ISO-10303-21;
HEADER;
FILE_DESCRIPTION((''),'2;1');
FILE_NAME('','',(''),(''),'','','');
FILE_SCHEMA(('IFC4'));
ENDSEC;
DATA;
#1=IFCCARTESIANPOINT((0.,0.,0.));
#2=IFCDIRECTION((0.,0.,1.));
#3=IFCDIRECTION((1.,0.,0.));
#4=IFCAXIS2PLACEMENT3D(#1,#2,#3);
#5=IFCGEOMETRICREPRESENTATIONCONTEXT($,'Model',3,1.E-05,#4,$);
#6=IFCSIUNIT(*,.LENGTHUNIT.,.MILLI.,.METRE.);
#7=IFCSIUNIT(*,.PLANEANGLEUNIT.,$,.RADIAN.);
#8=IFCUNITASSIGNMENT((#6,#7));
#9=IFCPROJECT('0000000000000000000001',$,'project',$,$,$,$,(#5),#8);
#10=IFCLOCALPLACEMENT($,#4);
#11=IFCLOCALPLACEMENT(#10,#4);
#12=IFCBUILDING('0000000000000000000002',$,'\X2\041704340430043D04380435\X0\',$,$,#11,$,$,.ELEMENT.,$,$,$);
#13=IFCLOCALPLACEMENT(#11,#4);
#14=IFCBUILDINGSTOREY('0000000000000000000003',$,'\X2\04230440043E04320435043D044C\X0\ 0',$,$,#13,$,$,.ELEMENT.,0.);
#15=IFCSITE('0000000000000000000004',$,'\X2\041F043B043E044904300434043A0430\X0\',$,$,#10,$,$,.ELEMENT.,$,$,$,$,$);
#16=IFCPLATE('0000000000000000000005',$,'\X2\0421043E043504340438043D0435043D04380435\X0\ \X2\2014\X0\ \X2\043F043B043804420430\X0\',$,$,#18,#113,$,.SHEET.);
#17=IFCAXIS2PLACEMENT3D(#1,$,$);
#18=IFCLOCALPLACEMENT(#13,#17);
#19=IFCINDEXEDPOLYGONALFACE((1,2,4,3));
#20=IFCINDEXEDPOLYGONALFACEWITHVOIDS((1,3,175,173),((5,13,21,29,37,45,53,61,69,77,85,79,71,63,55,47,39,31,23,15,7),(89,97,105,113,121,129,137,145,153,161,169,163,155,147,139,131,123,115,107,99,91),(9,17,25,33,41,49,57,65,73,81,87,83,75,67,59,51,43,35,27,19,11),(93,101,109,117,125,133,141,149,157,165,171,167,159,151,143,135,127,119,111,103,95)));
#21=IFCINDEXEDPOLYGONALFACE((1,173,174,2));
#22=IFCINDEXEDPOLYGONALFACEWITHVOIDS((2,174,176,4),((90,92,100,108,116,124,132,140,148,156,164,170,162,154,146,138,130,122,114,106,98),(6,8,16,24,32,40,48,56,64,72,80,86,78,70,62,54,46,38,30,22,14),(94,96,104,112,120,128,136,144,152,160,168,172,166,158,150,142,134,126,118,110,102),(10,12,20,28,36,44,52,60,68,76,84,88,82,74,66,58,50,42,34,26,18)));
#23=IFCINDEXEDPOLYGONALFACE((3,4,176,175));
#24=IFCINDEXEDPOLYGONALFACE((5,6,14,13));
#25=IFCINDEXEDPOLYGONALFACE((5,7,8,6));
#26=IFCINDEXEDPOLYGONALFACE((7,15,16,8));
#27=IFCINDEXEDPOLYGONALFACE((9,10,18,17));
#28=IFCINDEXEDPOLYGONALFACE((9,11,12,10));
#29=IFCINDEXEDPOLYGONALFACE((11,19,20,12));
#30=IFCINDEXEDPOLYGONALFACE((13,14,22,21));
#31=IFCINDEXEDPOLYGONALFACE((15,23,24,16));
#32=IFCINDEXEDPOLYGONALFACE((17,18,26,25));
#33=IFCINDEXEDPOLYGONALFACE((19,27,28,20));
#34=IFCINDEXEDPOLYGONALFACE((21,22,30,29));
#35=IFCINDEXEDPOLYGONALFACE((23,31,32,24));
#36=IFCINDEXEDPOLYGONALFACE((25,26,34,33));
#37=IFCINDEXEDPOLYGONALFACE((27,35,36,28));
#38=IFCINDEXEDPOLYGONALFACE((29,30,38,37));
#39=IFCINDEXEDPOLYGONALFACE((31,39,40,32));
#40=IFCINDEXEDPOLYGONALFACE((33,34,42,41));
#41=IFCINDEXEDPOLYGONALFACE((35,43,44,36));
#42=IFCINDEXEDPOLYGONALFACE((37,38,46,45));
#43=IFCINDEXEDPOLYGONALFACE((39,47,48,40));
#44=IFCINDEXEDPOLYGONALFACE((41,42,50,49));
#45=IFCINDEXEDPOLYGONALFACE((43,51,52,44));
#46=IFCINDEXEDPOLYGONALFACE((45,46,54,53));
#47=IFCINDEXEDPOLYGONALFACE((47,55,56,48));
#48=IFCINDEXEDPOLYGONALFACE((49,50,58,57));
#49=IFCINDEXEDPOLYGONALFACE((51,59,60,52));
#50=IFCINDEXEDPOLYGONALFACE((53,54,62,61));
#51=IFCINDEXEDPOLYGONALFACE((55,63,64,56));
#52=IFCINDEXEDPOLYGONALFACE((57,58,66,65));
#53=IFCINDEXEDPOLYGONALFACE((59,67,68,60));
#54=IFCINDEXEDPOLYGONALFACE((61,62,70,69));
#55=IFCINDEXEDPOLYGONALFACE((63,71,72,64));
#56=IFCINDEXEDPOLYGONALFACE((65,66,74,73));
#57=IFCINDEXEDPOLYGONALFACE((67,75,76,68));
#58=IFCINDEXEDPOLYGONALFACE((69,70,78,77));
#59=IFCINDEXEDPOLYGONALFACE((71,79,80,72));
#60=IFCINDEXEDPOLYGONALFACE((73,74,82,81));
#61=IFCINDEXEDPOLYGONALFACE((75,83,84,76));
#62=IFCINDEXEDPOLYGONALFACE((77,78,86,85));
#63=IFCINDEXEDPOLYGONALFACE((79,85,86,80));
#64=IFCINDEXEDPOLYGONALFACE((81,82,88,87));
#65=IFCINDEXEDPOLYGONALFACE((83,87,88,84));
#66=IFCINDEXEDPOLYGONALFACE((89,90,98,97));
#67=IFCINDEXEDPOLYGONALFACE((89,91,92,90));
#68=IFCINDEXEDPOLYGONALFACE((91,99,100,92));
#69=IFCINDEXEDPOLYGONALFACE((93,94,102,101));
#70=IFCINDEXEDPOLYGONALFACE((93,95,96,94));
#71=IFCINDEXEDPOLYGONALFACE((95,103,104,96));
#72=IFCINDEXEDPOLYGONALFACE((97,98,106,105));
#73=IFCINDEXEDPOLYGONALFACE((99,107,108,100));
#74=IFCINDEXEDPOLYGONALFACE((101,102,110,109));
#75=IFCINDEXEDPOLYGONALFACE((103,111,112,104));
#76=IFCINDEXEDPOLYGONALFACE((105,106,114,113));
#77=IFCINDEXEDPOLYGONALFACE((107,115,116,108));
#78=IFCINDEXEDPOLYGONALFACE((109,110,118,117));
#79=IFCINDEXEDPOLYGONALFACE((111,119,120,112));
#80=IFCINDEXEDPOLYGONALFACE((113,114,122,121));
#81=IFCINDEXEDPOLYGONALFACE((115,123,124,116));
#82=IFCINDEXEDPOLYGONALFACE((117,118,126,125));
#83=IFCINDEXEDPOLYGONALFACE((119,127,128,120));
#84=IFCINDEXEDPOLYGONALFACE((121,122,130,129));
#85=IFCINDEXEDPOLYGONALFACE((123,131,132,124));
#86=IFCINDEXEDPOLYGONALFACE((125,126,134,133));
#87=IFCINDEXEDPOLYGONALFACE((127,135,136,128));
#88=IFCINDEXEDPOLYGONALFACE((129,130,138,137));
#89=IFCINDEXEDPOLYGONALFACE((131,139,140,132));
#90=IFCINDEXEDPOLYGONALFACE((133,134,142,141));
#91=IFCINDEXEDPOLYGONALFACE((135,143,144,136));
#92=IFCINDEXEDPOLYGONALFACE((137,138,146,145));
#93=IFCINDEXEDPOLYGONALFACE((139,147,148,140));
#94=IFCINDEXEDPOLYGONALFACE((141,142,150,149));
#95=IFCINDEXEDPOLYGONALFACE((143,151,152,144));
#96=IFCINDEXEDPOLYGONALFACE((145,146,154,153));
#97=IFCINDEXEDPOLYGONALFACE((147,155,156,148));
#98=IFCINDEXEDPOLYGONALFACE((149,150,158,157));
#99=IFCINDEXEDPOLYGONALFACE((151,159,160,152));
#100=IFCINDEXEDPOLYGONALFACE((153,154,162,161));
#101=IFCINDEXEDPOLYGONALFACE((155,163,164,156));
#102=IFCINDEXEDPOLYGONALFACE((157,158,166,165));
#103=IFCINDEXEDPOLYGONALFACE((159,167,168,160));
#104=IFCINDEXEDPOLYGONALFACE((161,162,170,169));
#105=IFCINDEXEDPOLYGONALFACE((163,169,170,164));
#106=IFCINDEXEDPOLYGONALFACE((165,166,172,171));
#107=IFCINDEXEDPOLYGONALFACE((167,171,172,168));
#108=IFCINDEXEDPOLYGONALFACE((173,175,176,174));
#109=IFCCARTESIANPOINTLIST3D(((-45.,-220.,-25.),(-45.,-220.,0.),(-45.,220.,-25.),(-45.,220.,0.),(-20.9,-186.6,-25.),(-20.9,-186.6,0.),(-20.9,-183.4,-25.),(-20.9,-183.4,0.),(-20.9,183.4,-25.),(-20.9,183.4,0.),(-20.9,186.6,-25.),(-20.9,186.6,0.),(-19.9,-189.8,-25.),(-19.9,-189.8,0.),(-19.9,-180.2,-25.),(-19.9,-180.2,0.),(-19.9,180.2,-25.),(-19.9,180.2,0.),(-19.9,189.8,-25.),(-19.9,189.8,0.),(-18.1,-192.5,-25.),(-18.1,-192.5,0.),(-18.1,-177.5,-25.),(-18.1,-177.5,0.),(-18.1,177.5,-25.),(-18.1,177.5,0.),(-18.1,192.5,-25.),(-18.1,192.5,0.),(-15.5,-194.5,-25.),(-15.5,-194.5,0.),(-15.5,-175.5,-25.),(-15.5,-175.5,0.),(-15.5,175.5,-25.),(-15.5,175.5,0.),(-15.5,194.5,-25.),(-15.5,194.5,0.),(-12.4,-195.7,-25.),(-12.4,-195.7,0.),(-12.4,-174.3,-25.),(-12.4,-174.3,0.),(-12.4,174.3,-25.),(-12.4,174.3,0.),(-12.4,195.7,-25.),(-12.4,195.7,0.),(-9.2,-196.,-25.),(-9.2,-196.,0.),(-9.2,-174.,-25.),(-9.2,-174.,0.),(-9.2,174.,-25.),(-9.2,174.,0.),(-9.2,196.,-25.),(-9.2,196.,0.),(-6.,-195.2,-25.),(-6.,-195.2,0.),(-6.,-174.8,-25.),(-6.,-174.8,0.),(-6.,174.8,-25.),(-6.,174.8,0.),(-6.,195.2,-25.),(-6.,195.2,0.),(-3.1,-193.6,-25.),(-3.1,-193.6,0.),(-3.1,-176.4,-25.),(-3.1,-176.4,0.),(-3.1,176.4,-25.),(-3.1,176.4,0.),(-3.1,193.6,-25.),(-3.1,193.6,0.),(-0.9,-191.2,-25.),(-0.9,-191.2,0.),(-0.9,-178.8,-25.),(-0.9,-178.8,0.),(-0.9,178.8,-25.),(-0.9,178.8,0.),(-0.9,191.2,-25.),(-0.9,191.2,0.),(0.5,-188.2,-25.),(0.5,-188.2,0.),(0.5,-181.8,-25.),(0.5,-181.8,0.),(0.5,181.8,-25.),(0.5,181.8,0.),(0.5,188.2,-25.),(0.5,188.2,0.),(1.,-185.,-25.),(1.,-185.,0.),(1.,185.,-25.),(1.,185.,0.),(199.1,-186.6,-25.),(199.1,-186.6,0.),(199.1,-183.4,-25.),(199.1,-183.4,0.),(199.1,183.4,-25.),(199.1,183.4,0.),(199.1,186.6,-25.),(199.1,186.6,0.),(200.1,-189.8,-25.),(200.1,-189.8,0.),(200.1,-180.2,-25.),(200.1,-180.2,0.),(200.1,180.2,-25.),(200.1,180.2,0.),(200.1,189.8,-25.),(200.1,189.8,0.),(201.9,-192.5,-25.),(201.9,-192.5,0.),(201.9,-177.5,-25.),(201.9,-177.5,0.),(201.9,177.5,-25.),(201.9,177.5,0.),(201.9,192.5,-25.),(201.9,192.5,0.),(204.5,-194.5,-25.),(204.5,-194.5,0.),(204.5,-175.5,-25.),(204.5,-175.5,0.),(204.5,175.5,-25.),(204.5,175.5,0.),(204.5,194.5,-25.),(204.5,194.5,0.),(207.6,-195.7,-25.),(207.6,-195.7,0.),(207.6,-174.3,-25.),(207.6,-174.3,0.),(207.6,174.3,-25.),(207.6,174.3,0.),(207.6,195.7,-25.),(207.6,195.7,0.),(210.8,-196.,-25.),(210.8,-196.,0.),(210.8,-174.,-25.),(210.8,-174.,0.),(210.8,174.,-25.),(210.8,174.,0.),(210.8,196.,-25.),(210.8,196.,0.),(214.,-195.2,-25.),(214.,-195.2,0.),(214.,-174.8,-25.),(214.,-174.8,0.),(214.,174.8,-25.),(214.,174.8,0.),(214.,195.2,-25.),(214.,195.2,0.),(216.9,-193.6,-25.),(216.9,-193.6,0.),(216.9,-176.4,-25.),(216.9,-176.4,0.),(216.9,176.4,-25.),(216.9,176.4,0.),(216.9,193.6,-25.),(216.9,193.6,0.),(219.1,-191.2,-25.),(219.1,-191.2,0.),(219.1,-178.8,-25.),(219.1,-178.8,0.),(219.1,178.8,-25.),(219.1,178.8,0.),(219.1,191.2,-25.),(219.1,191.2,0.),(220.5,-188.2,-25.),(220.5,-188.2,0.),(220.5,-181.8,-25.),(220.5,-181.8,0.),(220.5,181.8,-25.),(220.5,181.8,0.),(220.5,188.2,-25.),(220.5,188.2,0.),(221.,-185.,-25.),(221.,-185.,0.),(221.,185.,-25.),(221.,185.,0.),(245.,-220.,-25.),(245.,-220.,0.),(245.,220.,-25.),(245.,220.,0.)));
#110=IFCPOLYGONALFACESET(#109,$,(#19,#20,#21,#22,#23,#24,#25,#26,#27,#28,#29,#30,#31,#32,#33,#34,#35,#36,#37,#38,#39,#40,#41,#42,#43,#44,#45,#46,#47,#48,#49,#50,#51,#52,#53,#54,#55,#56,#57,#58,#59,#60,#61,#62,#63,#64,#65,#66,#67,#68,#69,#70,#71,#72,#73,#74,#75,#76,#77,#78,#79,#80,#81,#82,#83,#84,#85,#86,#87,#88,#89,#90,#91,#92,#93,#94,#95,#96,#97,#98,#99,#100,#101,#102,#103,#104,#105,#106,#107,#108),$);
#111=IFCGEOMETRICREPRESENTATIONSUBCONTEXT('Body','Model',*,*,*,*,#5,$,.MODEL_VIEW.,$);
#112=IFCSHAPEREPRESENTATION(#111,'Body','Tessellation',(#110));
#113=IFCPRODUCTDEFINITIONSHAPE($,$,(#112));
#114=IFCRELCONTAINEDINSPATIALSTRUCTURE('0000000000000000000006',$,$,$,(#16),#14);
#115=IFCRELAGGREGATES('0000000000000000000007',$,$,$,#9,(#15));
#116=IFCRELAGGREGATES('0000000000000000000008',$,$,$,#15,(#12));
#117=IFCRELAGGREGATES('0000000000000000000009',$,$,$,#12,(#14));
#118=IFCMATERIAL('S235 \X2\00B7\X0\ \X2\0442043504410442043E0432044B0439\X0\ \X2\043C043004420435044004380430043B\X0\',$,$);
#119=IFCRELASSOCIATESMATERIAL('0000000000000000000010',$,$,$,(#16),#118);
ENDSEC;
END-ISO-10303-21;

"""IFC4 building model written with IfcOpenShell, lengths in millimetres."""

from ifc_helpers import new_model, si_unit, frame, origin_with_axes, place, context, subcontext, project, spatial, polyline, circle, outline, extrude, material, element, save


model = new_model("IFC4")

# Units and contexts
model_context = context("Model", 3, precision=1e-05, world=origin_with_axes())
body_context = subcontext(model_context, "Body", "Model", "MODEL_VIEW")
ifc_project = project(units=[si_unit("LENGTHUNIT", "METRE", prefix="MILLI"), si_unit("PLANEANGLEUNIT", "RADIAN")], contexts=[model_context])

# Site, building, storey
site_placement = place(None, origin_with_axes())
site = spatial("IfcSite", under=ifc_project, at=site_placement, Name="Площадка", CompositionType="ELEMENT")
building_placement = place(site_placement, origin_with_axes())
building = spatial("IfcBuilding", under=site, at=building_placement, Name="Здание", CompositionType="ELEMENT")
storey_placement = place(building_placement, origin_with_axes())
storey = spatial("IfcBuildingStorey", under=building, at=storey_placement, Name="Уровень 0", CompositionType="ELEMENT", Elevation=0.0)

# Shared definitions
ifc_material = material(Name="S235 · тестовый материал")

# Plate, openings
plate_1_placement = place(storey_placement, frame((-45.0, -220.0, -25.0), z_axis=(0.0, 0.0, 1.0), x_axis=(1.0, 0.0, 0.0)))
plate_1 = element("IfcPlate", 1, at=plate_1_placement, inside=storey, material=ifc_material, Name="Соединение — плита", PredefinedType="SHEET", context=body_context, shape_type="SweptSolid", body=[
    extrude(outline(polyline([(0.0, 0.0), (290.0, 0.0), (290.0, 440.0), (0.0, 440.0), (0.0, 0.0)])), origin_with_axes(), (0.0, 0.0, 1.0), 25.0),
])
opening_1_placement = place(plate_1_placement, frame((35.0, 35.0, -1.0), z_axis=(0.0, 0.0, 1.0), x_axis=(1.0, 0.0, 0.0)))
element("IfcOpeningElement", 2, at=opening_1_placement, cuts=plate_1, PredefinedType="OPENING", context=body_context, shape_type="SweptSolid", body=[
    extrude(circle(Radius=11.0), origin_with_axes(), (0.0, 0.0, 1.0), 27.0),
])
opening_2_placement = place(plate_1_placement, frame((255.0, 35.0, -1.0), z_axis=(0.0, 0.0, 1.0), x_axis=(1.0, 0.0, 0.0)))
element("IfcOpeningElement", 3, at=opening_2_placement, cuts=plate_1, PredefinedType="OPENING", context=body_context, shape_type="SweptSolid", body=[
    extrude(circle(Radius=11.0), origin_with_axes(), (0.0, 0.0, 1.0), 27.0),
])
opening_3_placement = place(plate_1_placement, frame((35.0, 405.0, -1.0), z_axis=(0.0, 0.0, 1.0), x_axis=(1.0, 0.0, 0.0)))
element("IfcOpeningElement", 4, at=opening_3_placement, cuts=plate_1, PredefinedType="OPENING", context=body_context, shape_type="SweptSolid", body=[
    extrude(circle(Radius=11.0), origin_with_axes(), (0.0, 0.0, 1.0), 27.0),
])
opening_4_placement = place(plate_1_placement, frame((255.0, 405.0, -1.0), z_axis=(0.0, 0.0, 1.0), x_axis=(1.0, 0.0, 0.0)))
element("IfcOpeningElement", 5, at=opening_4_placement, cuts=plate_1, PredefinedType="OPENING", context=body_context, shape_type="SweptSolid", body=[
    extrude(circle(Radius=11.0), origin_with_axes(), (0.0, 0.0, 1.0), 27.0),
])

save(model, "model.ifc")
